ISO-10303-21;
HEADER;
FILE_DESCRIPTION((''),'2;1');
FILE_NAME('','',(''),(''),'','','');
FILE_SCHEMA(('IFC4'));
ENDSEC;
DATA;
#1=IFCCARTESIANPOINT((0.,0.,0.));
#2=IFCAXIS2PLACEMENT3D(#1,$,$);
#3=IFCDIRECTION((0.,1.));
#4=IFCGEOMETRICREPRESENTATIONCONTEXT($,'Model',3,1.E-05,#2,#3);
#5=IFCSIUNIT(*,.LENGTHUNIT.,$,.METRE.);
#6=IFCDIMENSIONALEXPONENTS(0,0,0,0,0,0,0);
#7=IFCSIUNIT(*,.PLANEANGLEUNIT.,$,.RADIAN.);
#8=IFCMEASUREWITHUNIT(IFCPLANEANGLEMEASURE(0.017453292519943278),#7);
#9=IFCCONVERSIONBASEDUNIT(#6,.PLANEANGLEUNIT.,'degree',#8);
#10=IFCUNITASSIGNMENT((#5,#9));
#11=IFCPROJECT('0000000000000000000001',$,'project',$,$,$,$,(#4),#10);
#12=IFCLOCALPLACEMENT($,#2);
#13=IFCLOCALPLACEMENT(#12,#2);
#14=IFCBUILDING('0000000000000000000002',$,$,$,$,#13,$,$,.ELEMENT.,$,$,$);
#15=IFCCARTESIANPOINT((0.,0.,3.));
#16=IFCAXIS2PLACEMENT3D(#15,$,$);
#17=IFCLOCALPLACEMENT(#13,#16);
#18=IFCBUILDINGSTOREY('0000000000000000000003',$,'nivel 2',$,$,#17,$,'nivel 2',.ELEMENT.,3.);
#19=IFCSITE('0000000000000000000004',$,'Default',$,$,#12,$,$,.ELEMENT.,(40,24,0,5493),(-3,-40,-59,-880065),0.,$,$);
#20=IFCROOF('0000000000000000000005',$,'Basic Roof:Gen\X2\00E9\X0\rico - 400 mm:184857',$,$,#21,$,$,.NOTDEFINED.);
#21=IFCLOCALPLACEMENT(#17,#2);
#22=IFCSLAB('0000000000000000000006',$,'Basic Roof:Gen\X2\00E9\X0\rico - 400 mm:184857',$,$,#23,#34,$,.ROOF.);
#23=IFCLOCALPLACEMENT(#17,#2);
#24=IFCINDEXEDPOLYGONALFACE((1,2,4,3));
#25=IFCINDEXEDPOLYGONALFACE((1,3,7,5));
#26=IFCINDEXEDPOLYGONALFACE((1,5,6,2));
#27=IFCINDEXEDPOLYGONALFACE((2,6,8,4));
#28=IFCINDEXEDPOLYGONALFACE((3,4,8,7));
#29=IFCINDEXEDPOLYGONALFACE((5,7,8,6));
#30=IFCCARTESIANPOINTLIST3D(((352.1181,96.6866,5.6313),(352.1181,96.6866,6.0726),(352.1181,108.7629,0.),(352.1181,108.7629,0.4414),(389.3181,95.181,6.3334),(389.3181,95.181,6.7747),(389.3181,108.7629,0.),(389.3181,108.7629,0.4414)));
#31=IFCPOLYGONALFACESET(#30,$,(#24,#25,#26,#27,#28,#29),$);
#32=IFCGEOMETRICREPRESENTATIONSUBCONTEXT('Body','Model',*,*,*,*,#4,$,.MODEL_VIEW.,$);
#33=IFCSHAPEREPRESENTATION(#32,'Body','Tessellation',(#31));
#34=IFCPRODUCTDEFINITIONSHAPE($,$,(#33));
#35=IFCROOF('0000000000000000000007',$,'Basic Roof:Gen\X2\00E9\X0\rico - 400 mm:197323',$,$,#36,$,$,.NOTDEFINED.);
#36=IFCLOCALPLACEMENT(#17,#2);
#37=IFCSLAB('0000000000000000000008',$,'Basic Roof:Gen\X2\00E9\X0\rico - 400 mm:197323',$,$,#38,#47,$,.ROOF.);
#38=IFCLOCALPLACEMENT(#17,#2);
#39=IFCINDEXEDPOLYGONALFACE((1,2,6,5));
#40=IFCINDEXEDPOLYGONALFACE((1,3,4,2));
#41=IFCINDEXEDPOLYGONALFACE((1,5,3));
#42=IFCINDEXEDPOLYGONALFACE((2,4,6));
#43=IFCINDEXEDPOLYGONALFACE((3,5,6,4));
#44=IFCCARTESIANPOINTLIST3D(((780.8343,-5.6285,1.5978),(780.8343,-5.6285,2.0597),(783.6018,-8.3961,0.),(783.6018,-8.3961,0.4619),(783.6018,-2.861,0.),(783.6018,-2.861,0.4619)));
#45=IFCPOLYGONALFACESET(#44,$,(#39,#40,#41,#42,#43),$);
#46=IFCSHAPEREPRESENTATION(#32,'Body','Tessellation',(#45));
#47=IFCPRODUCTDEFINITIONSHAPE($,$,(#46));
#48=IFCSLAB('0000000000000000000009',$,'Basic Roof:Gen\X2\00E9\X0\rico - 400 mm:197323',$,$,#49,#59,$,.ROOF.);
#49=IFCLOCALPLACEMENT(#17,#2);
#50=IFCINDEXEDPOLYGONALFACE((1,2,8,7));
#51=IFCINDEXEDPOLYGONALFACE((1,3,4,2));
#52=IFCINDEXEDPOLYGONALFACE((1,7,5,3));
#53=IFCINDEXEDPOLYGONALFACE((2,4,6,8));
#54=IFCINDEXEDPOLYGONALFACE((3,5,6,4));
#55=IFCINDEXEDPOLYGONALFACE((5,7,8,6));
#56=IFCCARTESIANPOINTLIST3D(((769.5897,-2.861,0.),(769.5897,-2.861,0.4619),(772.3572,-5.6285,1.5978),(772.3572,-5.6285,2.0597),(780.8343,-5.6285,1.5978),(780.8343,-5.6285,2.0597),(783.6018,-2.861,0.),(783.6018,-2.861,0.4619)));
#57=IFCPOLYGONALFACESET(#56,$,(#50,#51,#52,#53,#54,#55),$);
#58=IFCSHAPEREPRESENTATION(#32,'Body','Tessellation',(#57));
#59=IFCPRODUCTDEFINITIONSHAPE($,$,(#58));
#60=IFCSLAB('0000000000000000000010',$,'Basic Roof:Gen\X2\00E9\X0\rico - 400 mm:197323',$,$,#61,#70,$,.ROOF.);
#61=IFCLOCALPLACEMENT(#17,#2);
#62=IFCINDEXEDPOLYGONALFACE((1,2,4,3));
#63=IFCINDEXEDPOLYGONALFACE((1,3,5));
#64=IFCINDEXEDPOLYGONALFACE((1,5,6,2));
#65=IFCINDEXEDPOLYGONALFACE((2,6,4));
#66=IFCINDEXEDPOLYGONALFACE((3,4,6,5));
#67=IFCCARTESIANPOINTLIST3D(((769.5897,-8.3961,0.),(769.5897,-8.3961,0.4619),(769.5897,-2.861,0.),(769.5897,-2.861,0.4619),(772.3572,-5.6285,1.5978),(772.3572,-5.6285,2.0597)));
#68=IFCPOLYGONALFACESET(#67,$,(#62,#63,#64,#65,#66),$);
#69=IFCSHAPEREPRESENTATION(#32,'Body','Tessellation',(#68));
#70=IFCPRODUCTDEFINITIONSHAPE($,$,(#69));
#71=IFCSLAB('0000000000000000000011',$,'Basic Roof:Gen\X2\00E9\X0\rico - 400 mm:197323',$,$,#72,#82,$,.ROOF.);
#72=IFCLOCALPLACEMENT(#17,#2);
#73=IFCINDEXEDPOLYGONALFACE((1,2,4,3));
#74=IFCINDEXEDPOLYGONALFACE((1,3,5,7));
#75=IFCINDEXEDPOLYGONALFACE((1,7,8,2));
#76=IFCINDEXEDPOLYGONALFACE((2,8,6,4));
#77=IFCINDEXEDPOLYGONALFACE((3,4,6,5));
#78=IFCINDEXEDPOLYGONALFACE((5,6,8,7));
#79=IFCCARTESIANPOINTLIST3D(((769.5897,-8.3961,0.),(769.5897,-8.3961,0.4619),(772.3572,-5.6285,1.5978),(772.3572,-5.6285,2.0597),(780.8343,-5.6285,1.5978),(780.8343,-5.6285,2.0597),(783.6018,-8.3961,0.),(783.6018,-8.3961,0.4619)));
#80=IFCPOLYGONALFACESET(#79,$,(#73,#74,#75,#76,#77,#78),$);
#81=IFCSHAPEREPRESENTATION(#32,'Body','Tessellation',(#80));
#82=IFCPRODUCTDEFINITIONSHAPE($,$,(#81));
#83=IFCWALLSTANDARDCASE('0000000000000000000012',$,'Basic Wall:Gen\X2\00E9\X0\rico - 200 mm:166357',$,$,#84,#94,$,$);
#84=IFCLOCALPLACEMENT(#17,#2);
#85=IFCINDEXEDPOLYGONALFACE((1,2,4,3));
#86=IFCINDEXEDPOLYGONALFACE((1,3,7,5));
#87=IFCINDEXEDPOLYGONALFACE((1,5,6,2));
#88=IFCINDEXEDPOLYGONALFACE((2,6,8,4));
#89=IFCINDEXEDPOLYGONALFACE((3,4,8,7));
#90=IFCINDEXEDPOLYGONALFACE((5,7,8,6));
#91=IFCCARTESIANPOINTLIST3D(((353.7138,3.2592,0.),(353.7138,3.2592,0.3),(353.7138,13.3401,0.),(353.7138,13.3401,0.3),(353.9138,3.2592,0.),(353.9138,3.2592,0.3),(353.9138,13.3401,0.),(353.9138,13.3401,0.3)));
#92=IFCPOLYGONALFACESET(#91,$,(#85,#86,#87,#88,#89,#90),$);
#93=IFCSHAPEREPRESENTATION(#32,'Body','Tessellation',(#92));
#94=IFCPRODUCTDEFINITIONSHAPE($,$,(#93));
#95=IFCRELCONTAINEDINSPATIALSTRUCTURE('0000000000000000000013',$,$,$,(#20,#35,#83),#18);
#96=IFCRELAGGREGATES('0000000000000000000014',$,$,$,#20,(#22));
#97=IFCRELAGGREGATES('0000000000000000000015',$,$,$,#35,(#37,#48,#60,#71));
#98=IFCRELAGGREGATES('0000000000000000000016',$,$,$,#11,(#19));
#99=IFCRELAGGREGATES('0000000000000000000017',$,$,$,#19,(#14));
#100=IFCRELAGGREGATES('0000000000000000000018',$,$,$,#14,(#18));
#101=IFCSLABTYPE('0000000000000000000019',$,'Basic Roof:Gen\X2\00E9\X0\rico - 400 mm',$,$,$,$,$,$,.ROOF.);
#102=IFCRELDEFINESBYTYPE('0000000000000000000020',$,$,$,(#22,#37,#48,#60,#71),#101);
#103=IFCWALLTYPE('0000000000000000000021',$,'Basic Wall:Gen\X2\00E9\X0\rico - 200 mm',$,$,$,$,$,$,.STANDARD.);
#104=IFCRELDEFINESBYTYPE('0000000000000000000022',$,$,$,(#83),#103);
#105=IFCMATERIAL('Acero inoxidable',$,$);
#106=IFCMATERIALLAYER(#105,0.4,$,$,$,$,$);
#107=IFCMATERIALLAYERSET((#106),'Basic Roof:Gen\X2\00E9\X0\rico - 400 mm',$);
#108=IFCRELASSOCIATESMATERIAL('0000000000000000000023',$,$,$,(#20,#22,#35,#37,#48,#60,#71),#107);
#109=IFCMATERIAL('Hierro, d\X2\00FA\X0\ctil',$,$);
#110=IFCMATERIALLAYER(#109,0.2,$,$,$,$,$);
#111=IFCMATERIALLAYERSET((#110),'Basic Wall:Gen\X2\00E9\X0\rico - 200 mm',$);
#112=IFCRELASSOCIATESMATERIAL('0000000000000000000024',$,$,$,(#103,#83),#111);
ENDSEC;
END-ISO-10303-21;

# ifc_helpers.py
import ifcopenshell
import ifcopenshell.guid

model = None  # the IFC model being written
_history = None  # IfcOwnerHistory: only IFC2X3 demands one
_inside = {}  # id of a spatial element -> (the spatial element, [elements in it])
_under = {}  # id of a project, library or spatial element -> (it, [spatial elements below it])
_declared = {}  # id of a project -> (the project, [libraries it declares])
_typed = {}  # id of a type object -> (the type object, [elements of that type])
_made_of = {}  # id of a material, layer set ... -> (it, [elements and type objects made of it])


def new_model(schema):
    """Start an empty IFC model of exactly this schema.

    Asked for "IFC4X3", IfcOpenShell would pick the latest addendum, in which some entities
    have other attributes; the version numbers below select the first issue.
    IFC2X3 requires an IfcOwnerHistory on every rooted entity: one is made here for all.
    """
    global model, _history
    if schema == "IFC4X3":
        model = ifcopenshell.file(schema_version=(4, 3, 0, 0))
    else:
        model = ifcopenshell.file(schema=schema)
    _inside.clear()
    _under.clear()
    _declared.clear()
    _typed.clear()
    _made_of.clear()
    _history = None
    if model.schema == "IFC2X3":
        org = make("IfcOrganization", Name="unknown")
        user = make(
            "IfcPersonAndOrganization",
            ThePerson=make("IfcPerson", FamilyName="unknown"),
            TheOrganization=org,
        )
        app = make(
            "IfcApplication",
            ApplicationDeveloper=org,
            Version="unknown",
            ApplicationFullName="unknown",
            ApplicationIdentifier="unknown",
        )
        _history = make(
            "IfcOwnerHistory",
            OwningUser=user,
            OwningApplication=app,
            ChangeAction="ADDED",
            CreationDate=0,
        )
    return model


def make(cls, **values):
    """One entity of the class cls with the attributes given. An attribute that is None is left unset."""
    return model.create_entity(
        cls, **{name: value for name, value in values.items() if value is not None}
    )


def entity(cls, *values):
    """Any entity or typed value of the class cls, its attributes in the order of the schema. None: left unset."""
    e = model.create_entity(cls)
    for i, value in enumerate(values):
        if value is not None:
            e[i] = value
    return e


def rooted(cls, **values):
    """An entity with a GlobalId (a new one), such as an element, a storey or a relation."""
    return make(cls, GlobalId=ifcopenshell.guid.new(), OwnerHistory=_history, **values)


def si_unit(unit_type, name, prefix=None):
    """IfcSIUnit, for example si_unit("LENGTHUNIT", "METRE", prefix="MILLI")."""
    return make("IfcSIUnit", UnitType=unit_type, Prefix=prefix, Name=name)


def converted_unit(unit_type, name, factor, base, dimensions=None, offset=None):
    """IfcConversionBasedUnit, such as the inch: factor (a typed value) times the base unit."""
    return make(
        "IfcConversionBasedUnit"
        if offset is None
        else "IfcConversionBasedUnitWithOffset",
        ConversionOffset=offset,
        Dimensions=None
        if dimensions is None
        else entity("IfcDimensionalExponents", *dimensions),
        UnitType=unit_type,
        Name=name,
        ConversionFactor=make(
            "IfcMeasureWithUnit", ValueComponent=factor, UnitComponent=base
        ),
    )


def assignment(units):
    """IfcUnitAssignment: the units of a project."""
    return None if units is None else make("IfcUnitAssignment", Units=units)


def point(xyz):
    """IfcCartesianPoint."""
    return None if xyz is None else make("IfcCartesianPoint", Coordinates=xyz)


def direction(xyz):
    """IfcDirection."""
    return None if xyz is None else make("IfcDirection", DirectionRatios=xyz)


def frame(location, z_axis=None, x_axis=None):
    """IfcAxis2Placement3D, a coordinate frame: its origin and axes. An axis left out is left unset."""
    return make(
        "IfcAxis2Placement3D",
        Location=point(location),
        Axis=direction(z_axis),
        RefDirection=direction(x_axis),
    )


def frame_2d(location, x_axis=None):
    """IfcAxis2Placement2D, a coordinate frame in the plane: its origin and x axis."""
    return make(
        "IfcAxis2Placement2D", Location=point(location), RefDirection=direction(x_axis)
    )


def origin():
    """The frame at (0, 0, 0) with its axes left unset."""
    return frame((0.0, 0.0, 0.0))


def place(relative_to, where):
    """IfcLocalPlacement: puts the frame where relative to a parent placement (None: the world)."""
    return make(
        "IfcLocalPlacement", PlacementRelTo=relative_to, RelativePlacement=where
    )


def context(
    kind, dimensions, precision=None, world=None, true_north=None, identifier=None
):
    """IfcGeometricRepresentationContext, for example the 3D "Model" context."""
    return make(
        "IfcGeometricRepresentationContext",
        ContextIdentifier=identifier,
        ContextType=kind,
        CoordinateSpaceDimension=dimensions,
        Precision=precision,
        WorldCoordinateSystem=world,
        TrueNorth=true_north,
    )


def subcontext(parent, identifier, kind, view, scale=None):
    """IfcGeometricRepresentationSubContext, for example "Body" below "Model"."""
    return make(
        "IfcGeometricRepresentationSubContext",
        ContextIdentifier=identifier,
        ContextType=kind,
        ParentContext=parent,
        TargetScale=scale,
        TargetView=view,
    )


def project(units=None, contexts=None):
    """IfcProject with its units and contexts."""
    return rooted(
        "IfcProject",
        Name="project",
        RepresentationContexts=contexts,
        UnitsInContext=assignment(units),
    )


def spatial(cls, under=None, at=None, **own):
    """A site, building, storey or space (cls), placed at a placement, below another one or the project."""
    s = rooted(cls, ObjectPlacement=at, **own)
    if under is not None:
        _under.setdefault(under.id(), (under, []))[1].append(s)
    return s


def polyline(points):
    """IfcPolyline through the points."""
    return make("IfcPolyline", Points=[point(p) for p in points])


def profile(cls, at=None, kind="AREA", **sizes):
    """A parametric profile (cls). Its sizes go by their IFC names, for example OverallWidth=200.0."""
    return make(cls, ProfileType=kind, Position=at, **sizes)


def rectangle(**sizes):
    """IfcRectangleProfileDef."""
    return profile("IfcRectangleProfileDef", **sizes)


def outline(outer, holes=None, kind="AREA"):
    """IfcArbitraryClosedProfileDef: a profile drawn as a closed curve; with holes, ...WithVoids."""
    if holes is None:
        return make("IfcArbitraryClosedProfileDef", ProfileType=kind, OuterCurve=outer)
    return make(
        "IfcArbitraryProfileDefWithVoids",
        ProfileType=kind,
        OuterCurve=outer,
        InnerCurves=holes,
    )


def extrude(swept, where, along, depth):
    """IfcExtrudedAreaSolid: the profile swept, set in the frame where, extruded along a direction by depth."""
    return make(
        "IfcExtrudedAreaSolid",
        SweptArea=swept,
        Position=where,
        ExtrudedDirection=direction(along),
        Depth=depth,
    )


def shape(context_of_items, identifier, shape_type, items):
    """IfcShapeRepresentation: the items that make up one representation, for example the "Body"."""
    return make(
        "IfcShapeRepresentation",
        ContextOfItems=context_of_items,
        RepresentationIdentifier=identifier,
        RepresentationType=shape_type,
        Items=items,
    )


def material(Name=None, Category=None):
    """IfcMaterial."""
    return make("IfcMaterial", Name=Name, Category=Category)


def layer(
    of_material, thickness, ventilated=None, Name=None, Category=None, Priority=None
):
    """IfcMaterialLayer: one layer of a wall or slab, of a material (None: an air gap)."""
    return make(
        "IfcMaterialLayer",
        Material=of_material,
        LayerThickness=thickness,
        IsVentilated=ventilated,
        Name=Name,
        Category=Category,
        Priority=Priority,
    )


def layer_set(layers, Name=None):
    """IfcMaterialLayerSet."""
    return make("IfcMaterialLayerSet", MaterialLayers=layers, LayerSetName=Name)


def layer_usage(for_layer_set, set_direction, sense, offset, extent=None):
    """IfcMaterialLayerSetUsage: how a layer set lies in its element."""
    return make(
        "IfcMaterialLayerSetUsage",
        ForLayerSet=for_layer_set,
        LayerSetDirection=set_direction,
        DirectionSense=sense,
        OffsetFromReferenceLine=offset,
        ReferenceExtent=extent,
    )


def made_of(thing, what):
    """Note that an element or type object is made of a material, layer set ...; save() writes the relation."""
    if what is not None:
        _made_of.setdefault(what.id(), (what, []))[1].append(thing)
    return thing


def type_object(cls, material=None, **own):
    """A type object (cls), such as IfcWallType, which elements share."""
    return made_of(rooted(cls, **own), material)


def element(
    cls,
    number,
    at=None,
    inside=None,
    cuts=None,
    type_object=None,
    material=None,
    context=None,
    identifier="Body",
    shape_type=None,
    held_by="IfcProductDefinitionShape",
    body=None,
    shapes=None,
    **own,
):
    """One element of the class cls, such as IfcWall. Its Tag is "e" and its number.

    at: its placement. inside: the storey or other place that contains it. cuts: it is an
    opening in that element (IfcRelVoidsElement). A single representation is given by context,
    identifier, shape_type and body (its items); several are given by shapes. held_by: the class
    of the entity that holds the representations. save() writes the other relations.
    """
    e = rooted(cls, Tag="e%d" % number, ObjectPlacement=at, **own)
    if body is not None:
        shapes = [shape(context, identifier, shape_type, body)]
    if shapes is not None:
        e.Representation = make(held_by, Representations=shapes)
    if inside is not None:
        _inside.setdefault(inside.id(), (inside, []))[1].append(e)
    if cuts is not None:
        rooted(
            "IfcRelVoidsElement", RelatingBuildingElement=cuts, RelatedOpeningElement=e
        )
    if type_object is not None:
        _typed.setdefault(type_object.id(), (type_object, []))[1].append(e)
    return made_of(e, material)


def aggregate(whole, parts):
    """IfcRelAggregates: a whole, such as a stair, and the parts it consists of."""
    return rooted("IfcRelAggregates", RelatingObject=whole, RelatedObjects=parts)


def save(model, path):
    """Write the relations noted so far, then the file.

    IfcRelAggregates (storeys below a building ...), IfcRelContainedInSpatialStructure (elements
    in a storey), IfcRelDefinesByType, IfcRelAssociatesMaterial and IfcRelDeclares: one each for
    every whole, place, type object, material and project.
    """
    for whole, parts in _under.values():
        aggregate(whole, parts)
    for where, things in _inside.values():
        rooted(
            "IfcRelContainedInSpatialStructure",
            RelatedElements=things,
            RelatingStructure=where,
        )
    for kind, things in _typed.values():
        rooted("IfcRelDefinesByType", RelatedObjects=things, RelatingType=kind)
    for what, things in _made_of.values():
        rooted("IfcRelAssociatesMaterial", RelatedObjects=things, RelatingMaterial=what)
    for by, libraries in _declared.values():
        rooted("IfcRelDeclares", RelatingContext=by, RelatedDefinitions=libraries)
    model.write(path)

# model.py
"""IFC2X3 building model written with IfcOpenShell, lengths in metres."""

from ifc_helpers import new_model, entity, si_unit, converted_unit, direction, frame, frame_2d, origin, place, context, subcontext, project, spatial, polyline, rectangle, outline, extrude, material, layer, layer_set, layer_usage, type_object, element, aggregate, save


model = new_model("IFC2X3")

# Units and contexts
model_context = context("Model", 3, precision=1e-05, world=origin(), true_north=direction((0.0, 1.0)))
body_context = subcontext(model_context, "Body", "Model", "MODEL_VIEW")
ifc_project = project(units=[si_unit("LENGTHUNIT", "METRE"), converted_unit("PLANEANGLEUNIT", "degree", entity("IfcPlaneAngleMeasure", 0.017453292519943278), si_unit("PLANEANGLEUNIT", "RADIAN"), dimensions=[0, 0, 0, 0, 0, 0, 0])], contexts=[model_context])

# Site, building, storey
site_placement = place(None, origin())
site = spatial("IfcSite", under=ifc_project, at=site_placement, Name="Default", CompositionType="ELEMENT", RefLatitude=(40, 24, 0, 5493), RefLongitude=(-3, -40, -59, -880065), RefElevation=0.0)
building_placement = place(site_placement, origin())
building = spatial("IfcBuilding", under=site, at=building_placement, CompositionType="ELEMENT")
storey_placement = place(building_placement, frame((0.0, 0.0, 3.0)))
storey = spatial("IfcBuildingStorey", under=building, at=storey_placement, Name="nivel 2", LongName="nivel 2", CompositionType="ELEMENT", Elevation=3.0)

# Shared definitions
ifc_material_1 = material(Name="Acero inoxidable")
ifc_layer_1 = layer(ifc_material_1, 0.4)
ifc_layer_set_1 = layer_set([ifc_layer_1], Name="Basic Roof:Genérico - 400 mm")
slab_type = type_object("IfcSlabType", Name="Basic Roof:Genérico - 400 mm", PredefinedType="ROOF")

# Roof, slab
roof_1_placement = place(storey_placement, frame((352.1181, 81.5545, 0.0)))
roof_1 = element("IfcRoof", 1, at=roof_1_placement, inside=storey, material=ifc_layer_set_1, Name="Basic Roof:Genérico - 400 mm:184857", ShapeType="NOTDEFINED")
slab_1_placement = place(roof_1_placement, origin())
slab_1 = element("IfcSlab", 2, at=slab_1_placement, type_object=slab_type, material=ifc_layer_set_1, Name="Basic Roof:Genérico - 400 mm:184857", PredefinedType="ROOF", context=body_context, shape_type="SweptSolid", body=[
    extrude(outline(polyline([(-18.6, -5.8317), (18.6, -7.493), (18.6, 7.493), (-18.6, 7.493), (-18.6, -5.8317)])), frame((18.6, 20.4175, 3.1667), z_axis=(0.0, 0.422618, 0.906308), x_axis=(1.0, 0.0, 0.0)), (0.0, -0.422618, 0.906308), 0.4414),
])
aggregate(roof_1, [slab_1])

# Roof, slabs
roof_2_placement = place(storey_placement, frame((769.5897, -8.3961, 0.0)))
roof_2 = element("IfcRoof", 3, at=roof_2_placement, inside=storey, material=ifc_layer_set_1, Name="Basic Roof:Genérico - 400 mm:197323", ShapeType="NOTDEFINED")
slab_2_placement = place(roof_2_placement, origin())
slab_2 = element("IfcSlab", 4, at=slab_2_placement, type_object=slab_type, material=ifc_layer_set_1, Name="Basic Roof:Genérico - 400 mm:197323", PredefinedType="ROOF", context=body_context, shape_type="SweptSolid", body=[
    extrude(outline(polyline([(1.5978, -2.7675), (1.5978, 2.7675), (-1.5978, 0.0), (1.5978, -2.7675)])), frame((12.6284, 2.7675, 0.7989), z_axis=(0.5, 0.0, 0.866025), x_axis=(0.866025, 0.0, -0.5)), (-0.5, 0.0, 0.866025), 0.4619),
])
slab_3_placement = place(roof_2_placement, origin())
slab_3 = element("IfcSlab", 5, at=slab_3_placement, type_object=slab_type, material=ifc_layer_set_1, Name="Basic Roof:Genérico - 400 mm:197323", PredefinedType="ROOF", context=body_context, shape_type="SweptSolid", body=[
    extrude(outline(polyline([(7.0061, 1.5978), (-7.0061, 1.5978), (-4.2385, -1.5978), (4.2385, -1.5978), (7.0061, 1.5978)])), frame((7.0061, 4.1513, 0.7989), z_axis=(0.0, 0.5, 0.866025), x_axis=(1.0, 0.0, 0.0)), (0.0, -0.5, 0.866025), 0.4619),
])
slab_4_placement = place(roof_2_placement, origin())
slab_4 = element("IfcSlab", 6, at=slab_4_placement, type_object=slab_type, material=ifc_layer_set_1, Name="Basic Roof:Genérico - 400 mm:197323", PredefinedType="ROOF", context=body_context, shape_type="SweptSolid", body=[
    extrude(outline(polyline([(-1.5978, 2.7675), (-1.5978, -2.7675), (1.5978, 0.0), (-1.5978, 2.7675)])), frame((1.3838, 2.7675, 0.7989), z_axis=(-0.5, 0.0, 0.866025), x_axis=(0.866025, 0.0, 0.5)), (0.5, 0.0, 0.866025), 0.4619),
])
slab_5_placement = place(roof_2_placement, origin())
slab_5 = element("IfcSlab", 7, at=slab_5_placement, type_object=slab_type, material=ifc_layer_set_1, Name="Basic Roof:Genérico - 400 mm:197323", PredefinedType="ROOF", context=body_context, shape_type="SweptSolid", body=[
    extrude(outline(polyline([(4.2385, 1.5978), (-4.2385, 1.5978), (-7.0061, -1.5978), (7.0061, -1.5978), (4.2385, 1.5978)])), frame((7.0061, 1.3838, 0.7989), z_axis=(0.0, -0.5, 0.866025), x_axis=(1.0, 0.0, 0.0)), (0.0, 0.5, 0.866025), 0.4619),
])
aggregate(roof_2, [slab_2, slab_3, slab_4, slab_5])

# Wall
ifc_material_2 = material(Name="Hierro, dúctil")
ifc_layer_2 = layer(ifc_material_2, 0.2)
ifc_layer_set_2 = layer_set([ifc_layer_2], Name="Basic Wall:Genérico - 200 mm")
ifc_layer_usage = layer_usage(ifc_layer_set_2, "AXIS2", "NEGATIVE", 0.1)
wall_type = type_object("IfcWallType", Name="Basic Wall:Genérico - 200 mm", PredefinedType="STANDARD", material=ifc_layer_set_2)
wall_placement = place(storey_placement, frame((353.8138, 3.2592, 0.0), z_axis=(0.0, 0.0, 1.0), x_axis=(0.0, 1.0, 0.0)))
element("IfcWallStandardCase", 8, at=wall_placement, inside=storey, type_object=wall_type, material=ifc_layer_usage, Name="Basic Wall:Genérico - 200 mm:166357", context=body_context, shape_type="SweptSolid", body=[
    extrude(rectangle(XDim=10.0809, YDim=0.2, at=frame_2d((5.0405, 0.0), x_axis=(-1.0, 0.0))), origin(), (0.0, 0.0, 1.0), 0.3),
])

save(model, "model.ifc")
